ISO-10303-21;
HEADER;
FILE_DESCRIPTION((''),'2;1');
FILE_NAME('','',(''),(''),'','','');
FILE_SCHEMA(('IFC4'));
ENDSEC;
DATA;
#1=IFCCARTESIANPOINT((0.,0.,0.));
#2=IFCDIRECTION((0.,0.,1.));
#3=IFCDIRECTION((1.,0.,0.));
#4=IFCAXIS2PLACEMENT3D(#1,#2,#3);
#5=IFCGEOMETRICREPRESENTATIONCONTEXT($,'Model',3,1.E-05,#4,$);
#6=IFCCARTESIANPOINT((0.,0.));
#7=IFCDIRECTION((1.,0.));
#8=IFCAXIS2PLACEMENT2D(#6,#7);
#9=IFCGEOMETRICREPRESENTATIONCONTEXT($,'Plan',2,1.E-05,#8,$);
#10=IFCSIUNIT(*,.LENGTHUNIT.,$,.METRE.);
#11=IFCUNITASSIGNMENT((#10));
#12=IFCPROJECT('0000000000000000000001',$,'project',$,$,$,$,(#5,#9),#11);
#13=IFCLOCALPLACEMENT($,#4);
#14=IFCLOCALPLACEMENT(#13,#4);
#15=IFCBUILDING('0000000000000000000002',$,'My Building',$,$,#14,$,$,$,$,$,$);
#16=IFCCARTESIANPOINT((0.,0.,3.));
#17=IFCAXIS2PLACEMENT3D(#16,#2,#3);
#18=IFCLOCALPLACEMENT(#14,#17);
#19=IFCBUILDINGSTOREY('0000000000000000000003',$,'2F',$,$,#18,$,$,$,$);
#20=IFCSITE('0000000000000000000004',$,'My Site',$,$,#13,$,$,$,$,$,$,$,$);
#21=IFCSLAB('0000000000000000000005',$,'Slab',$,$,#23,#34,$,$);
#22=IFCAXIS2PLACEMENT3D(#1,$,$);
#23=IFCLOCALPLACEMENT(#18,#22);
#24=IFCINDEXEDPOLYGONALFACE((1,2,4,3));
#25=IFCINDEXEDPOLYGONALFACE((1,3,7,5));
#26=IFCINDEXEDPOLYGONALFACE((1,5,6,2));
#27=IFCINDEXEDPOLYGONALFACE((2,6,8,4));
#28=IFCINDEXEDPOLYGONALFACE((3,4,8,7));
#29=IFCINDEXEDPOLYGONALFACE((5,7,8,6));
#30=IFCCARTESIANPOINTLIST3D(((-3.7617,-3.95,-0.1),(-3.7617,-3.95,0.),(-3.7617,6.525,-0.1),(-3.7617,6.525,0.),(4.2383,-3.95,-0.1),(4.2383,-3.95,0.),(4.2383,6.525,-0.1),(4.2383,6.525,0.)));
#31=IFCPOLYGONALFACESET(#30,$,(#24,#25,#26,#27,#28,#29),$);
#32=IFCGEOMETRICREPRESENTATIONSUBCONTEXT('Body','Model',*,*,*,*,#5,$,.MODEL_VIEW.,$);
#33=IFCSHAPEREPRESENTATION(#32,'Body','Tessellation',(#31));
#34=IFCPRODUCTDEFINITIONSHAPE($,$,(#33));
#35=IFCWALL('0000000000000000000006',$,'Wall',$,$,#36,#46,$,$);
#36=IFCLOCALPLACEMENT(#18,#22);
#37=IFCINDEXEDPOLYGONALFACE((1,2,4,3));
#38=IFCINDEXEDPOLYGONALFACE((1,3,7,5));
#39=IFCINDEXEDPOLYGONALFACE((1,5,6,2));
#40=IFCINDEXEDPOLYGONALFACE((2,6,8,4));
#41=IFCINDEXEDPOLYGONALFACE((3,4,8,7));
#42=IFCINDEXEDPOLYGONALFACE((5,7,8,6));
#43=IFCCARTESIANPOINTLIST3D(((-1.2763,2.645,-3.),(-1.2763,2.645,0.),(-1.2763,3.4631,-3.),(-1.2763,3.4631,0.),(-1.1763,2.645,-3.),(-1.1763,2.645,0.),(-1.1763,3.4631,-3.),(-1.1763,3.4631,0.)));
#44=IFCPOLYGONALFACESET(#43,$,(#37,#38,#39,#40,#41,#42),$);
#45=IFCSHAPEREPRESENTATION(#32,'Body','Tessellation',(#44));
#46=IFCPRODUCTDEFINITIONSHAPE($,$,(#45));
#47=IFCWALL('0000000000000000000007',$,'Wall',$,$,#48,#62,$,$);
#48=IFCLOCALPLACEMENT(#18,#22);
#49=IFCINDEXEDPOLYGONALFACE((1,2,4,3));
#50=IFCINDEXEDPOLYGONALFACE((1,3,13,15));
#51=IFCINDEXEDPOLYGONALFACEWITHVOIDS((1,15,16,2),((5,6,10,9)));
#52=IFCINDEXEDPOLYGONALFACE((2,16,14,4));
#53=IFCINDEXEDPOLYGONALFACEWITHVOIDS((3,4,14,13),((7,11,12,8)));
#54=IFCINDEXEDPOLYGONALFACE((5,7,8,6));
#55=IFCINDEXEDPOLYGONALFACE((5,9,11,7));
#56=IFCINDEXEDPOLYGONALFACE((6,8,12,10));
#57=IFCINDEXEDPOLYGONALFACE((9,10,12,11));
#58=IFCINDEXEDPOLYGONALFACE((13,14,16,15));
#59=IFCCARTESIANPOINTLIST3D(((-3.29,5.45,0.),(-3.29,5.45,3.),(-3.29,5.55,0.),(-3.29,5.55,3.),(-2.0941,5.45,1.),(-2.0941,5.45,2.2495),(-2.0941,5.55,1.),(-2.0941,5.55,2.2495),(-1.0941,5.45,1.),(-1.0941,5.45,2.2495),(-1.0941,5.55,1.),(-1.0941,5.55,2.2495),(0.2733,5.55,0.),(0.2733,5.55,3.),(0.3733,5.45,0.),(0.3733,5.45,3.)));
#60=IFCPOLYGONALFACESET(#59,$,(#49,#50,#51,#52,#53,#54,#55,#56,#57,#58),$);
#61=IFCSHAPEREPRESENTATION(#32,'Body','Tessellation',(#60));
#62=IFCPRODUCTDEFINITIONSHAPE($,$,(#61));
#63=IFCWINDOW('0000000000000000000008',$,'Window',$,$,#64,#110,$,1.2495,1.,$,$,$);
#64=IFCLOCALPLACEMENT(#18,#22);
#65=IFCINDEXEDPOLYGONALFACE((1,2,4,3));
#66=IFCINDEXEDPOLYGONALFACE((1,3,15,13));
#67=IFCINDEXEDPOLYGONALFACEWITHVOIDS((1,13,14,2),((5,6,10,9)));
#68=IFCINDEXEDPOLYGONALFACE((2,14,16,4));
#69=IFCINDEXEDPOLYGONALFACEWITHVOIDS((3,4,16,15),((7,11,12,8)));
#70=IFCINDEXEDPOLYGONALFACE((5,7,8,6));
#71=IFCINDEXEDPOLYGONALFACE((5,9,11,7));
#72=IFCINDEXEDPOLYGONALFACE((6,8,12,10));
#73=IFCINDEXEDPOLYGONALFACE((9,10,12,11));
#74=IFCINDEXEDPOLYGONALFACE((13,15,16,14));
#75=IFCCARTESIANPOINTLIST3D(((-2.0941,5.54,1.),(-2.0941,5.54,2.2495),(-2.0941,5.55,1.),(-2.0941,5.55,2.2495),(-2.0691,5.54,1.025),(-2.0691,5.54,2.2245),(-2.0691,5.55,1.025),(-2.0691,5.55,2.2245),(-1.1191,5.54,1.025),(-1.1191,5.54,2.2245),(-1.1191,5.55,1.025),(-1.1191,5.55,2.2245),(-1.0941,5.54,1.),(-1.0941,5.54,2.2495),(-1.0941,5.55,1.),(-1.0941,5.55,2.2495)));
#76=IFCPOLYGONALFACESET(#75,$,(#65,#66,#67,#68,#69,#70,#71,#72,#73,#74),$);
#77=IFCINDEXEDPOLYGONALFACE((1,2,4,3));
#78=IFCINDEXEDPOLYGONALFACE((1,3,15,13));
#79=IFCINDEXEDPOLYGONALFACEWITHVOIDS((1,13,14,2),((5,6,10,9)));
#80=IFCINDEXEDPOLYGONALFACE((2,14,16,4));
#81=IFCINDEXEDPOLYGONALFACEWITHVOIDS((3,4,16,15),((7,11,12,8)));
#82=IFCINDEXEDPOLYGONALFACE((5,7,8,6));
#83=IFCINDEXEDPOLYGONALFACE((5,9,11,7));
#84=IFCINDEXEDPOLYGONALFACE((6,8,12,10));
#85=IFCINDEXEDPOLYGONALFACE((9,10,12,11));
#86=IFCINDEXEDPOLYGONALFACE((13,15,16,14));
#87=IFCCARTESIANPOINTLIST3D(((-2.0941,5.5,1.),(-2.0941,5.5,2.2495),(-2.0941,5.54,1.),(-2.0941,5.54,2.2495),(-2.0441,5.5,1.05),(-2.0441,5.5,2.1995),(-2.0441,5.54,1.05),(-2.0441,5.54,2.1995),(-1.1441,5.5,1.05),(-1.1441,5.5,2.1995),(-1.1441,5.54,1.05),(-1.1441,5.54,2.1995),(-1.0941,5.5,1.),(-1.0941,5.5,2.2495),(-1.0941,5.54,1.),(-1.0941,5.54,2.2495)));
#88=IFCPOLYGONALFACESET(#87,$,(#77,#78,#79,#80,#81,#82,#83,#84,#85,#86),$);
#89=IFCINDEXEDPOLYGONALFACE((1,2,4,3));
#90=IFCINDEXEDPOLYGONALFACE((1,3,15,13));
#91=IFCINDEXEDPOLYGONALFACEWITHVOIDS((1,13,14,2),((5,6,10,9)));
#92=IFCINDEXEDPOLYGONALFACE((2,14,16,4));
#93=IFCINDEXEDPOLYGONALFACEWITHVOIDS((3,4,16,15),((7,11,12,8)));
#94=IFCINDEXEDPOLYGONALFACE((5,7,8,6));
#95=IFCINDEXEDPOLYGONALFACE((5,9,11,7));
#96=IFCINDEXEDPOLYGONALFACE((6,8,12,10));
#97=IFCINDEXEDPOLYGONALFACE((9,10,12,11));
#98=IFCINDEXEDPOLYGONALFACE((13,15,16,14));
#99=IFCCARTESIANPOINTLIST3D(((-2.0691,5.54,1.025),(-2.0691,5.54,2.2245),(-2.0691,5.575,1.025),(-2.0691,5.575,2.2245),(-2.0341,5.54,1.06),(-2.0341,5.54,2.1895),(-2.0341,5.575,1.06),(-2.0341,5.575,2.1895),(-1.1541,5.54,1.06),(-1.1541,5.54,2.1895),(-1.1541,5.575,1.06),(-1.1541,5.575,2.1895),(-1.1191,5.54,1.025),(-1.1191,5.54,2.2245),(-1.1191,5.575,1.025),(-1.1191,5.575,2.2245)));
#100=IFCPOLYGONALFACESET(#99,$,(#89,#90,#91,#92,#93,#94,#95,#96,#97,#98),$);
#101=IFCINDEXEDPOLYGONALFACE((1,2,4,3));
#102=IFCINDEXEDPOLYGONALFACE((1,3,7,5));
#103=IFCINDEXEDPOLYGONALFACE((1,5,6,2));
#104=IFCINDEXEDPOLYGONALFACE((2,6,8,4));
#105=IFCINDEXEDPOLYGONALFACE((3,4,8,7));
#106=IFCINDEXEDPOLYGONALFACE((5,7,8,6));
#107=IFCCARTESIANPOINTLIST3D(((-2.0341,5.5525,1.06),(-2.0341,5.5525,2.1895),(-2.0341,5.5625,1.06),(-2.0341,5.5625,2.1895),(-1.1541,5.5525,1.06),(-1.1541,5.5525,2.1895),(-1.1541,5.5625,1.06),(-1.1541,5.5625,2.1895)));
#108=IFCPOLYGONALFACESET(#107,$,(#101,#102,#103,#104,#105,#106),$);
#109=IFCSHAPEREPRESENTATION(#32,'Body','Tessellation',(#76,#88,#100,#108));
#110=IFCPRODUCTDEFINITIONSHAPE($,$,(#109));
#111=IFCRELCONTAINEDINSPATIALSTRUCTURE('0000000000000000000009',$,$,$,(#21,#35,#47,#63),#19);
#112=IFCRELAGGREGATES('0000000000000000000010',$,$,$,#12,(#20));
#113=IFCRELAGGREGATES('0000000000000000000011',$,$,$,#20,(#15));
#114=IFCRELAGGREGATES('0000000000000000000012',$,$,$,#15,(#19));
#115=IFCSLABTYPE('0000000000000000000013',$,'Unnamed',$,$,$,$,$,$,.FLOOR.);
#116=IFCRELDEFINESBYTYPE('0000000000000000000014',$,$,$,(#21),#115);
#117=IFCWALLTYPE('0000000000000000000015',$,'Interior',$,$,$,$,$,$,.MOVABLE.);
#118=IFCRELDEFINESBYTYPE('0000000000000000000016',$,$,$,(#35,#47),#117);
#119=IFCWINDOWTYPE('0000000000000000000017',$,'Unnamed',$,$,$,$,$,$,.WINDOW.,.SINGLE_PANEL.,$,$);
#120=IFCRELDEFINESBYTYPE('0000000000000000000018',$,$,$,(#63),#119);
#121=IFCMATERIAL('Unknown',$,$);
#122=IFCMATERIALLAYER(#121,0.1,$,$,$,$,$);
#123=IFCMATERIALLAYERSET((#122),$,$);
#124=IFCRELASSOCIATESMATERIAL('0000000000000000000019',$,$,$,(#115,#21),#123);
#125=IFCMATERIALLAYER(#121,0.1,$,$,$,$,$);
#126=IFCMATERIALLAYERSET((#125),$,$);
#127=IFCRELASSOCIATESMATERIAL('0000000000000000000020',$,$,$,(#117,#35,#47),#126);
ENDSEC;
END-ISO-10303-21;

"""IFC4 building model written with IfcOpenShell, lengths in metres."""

from ifc_helpers import new_model, entity, si_unit, frame, origin_with_axes, origin_2d_with_axis, place, context, subcontext, project, spatial, line, indexed_curve, outline, extrude, shape, source, transform, mapped, material, layer, layer_set, layer_usage, type_object, type_shapes, element, fill, save


model = new_model("IFC4")

# Units and contexts
model_context = context("Model", 3, precision=1e-05, world=origin_with_axes())
plan_context = context("Plan", 2, precision=1e-05, world=origin_2d_with_axis())
body_context_1 = subcontext(model_context, "Body", "Model", "MODEL_VIEW")
body_context_2 = subcontext(plan_context, "Body", "Plan", "PLAN_VIEW")
ifc_project = project(units=[si_unit("LENGTHUNIT", "METRE")], contexts=[model_context, plan_context])

# Site, building, storey
site_placement = place(None, origin_with_axes())
site = spatial("IfcSite", under=ifc_project, at=site_placement, Name="My Site")
building_placement = place(site_placement, origin_with_axes())
building = spatial("IfcBuilding", under=site, at=building_placement, Name="My Building")
storey_placement = place(building_placement, frame((0.0, 0.0, 3.0), z_axis=(0.0, 0.0, 1.0), x_axis=(1.0, 0.0, 0.0)))
storey = spatial("IfcBuildingStorey", under=building, at=storey_placement, Name="2F")

# Slab
ifc_material = material(Name="Unknown")
ifc_layer_1 = layer(ifc_material, 0.1)
ifc_layer_set_1 = layer_set([ifc_layer_1])
ifc_layer_usage_1 = layer_usage(ifc_layer_set_1, "AXIS3", "POSITIVE", -0.1)
slab_type = type_object("IfcSlabType", Name="Unnamed", PredefinedType="FLOOR", material=ifc_layer_set_1)
slab_placement = place(storey_placement, frame((4.2383, 6.525, 0.0), z_axis=(0.0, 0.0, 1.0), x_axis=(1.0, 0.0, 0.0)))
element("IfcSlab", 1, at=slab_placement, inside=storey, type_object=slab_type, material=ifc_layer_usage_1, Name="Slab", context=body_context_1, shape_type="SweptSolid", body=[
    extrude(outline(indexed_curve([(0.0, 0.0), (-8.0, 0.0), (-8.0, -10.475), (0.0, -10.475), (0.0, 0.0)])), frame((0.0, 0.0, -0.1), z_axis=(0.0, 0.0, 1.0), x_axis=(1.0, 0.0, 0.0)), (0.0, 0.0, 1.0), 0.1),
])

# Wall
ifc_layer_2 = layer(ifc_material, 0.1)
ifc_layer_set_2 = layer_set([ifc_layer_2])
ifc_layer_usage_2 = layer_usage(ifc_layer_set_2, "AXIS2", "POSITIVE", 0.0)
wall_type = type_object("IfcWallType", Name="Interior", PredefinedType="MOVABLE", material=ifc_layer_set_2)
wall_1_placement = place(storey_placement, frame((-1.2763, 3.4631, -3.0), z_axis=(0.0, 0.0, 1.0), x_axis=(0.0, -1.0, 0.0)))
element("IfcWall", 2, at=wall_1_placement, inside=storey, type_object=wall_type, material=ifc_layer_usage_2, Name="Wall", context=body_context_1, shape_type="SweptSolid", body=[
    extrude(outline(indexed_curve([(0.0, 0.0), (0.0, 0.1), (0.8182, 0.1), (0.8182, 0.0)], segments=[line(1, 2, 3, 4, 1)])), origin_with_axes(), (0.0, 0.0, 1.0), 3.0),
])

# Wall, opening, window
ifc_layer_usage_3 = layer_usage(ifc_layer_set_2, "AXIS2", "POSITIVE", 0.0)
wall_2_placement = place(storey_placement, frame((0.3733, 5.55, 0.0), z_axis=(0.0, 0.0, 1.0), x_axis=(-1.0, 0.0, 0.0)))
wall_2 = element("IfcWall", 3, at=wall_2_placement, inside=storey, type_object=wall_type, material=ifc_layer_usage_3, Name="Wall", context=body_context_1, shape_type="SweptSolid", body=[
    extrude(outline(indexed_curve([(0.1, 0.0), (0.0, 0.1), (3.6634, 0.1), (3.6634, 0.0)], segments=[line(1, 2, 3, 4, 1)])), origin_with_axes(), (0.0, 0.0, 1.0), 3.0),
])
shared_shape_1 = source(origin_with_axes(), body_context_1, "Body", "SweptSolid", [
    extrude(outline(indexed_curve([(0.0, 0.0), (1.0, 0.0), (1.0, 1.2495), (0.0, 1.2495)], segments=[line(1, 2, 3, 4, 1)])), frame((0.0, -0.6, 0.0), z_axis=(0.0, -1.0, 0.0), x_axis=(1.0, 0.0, 0.0)), (0.0, 0.0, -1.0), 1.2),
])
opening_1_placement = place(wall_2_placement, frame((2.4674, 0.1, 1.0), z_axis=(0.0, 0.0, 1.0), x_axis=(-1.0, 0.0, 0.0)))
opening_1 = element("IfcOpeningElement", 4, at=opening_1_placement, cuts=wall_2, PredefinedType="OPENING", context=body_context_1, shape_type="MappedRepresentation", body=[
    mapped(shared_shape_1, transform((0.0, 0.0, 0.0), x_axis=(1.0, 0.0, 0.0), y_axis=(0.0, 1.0, 0.0), z_axis=(0.0, 0.0, 1.0), scale=1.0)),
])
window_type = type_object("IfcWindowType", Name="Unnamed", PartitioningType="SINGLE_PANEL", PredefinedType="WINDOW")
shared_shape_2 = source(origin_with_axes(), body_context_1, "Body", "SweptSolid", [
    extrude(outline(indexed_curve([(0.0, 0.0), (1.0, 0.0), (1.0, 1.2495), (0.0, 1.2495)], segments=[line(1, 2, 3, 4, 1)]), holes=[indexed_curve([(0.025, 0.025), (0.975, 0.025), (0.975, 1.2245), (0.025, 1.2245)], segments=[line(1, 2, 3, 4, 1)])]), frame((0.0, 0.09, 0.0), z_axis=(0.0, -1.0, 0.0), x_axis=(1.0, 0.0, 0.0)), (0.0, 0.0, -1.0), 0.01),
    extrude(outline(indexed_curve([(0.0, 0.0), (1.0, 0.0), (1.0, 1.2495), (0.0, 1.2495)], segments=[line(1, 2, 3, 4, 1)]), holes=[indexed_curve([(0.05, 0.05), (0.95, 0.05), (0.95, 1.1995), (0.05, 1.1995)], segments=[line(1, 2, 3, 4, 1)])]), frame((0.0, 0.05, 0.0), z_axis=(0.0, -1.0, 0.0), x_axis=(1.0, 0.0, 0.0)), (0.0, 0.0, -1.0), 0.04),
    extrude(outline(indexed_curve([(0.0, 0.0), (0.95, 0.0), (0.95, 1.1995), (0.0, 1.1995)], segments=[line(1, 2, 3, 4, 1)]), holes=[indexed_curve([(0.035, 0.035), (0.915, 0.035), (0.915, 1.1645), (0.035, 1.1645)], segments=[line(1, 2, 3, 4, 1)])]), frame((0.025, 0.09, 0.025), z_axis=(0.0, -1.0, 0.0), x_axis=(1.0, 0.0, 0.0)), (0.0, 0.0, -1.0), 0.035),
    extrude(outline(indexed_curve([(0.035, 0.035), (0.915, 0.035), (0.915, 1.1645), (0.035, 1.1645)], segments=[line(1, 2, 3, 4, 1)])), frame((0.025, 0.1025, 0.025), z_axis=(0.0, -1.0, 0.0), x_axis=(1.0, 0.0, 0.0)), (0.0, 0.0, -1.0), 0.01),
])
shared_shape_3 = source(origin_with_axes(), body_context_2, "Body", "Curve2D", [
    entity("IfcIndexedPolyCurve", entity("IfcCartesianPointList2D", [[0.05, 0.05], [0.95, 0.05]])),
    entity("IfcIndexedPolyCurve", entity("IfcCartesianPointList2D", [[0.0, 0.1], [0.025, 0.1], [0.025, 0.09], [0.05, 0.09], [0.05, 0.05], [0.0, 0.05]]), [entity("IfcLineIndex", [1, 2, 3, 4, 5, 6, 1])]),
    entity("IfcIndexedPolyCurve", entity("IfcCartesianPointList2D", [[1.0, 0.1], [0.975, 0.1], [0.975, 0.09], [0.95, 0.09], [0.95, 0.05], [1.0, 0.05]]), [entity("IfcLineIndex", [1, 2, 3, 4, 5, 6, 1])]),
    entity("IfcIndexedPolyCurve", entity("IfcCartesianPointList2D", [[0.025, 0.09], [0.06, 0.09], [0.06, 0.125], [0.025, 0.125]]), [entity("IfcLineIndex", [1, 2, 3, 4, 1])]),
    entity("IfcIndexedPolyCurve", entity("IfcCartesianPointList2D", [[0.975, 0.09], [0.94, 0.09], [0.94, 0.125], [0.975, 0.125]]), [entity("IfcLineIndex", [1, 2, 3, 4, 1])]),
    entity("IfcIndexedPolyCurve", entity("IfcCartesianPointList2D", [[0.06, 0.09], [0.94, 0.09]])),
    entity("IfcIndexedPolyCurve", entity("IfcCartesianPointList2D", [[0.06, 0.125], [0.94, 0.125]])),
    entity("IfcIndexedPolyCurve", entity("IfcCartesianPointList2D", [[0.06, 0.1075], [0.94, 0.1075]])),
])
type_shapes(window_type, [shared_shape_2, shared_shape_3])
window_1_placement = place(opening_1_placement, frame((0.0, 0.0, 0.0), z_axis=(0.0, 0.0, 1.0), x_axis=(1.0, 0.0, 0.0)))
window_1 = element("IfcWindow", 5, at=window_1_placement, inside=storey, type_object=window_type, Name="Window", OverallHeight=1.2495, OverallWidth=1.0, shapes=[
    shape(body_context_1, "Body", "MappedRepresentation", [mapped(shared_shape_2, transform((0.0, 0.0, 0.0), x_axis=(1.0, 0.0, 0.0), y_axis=(0.0, 1.0, 0.0), z_axis=(0.0, 0.0, 1.0), scale=1.0))]),
    shape(body_context_2, "Body", "MappedRepresentation", [mapped(shared_shape_3, transform((0.0, 0.0, 0.0), x_axis=(1.0, 0.0, 0.0), y_axis=(0.0, 1.0, 0.0), z_axis=(0.0, 0.0, 1.0), scale=1.0))]),
])
fill(opening_1, window_1)

save(model, "model.ifc")
